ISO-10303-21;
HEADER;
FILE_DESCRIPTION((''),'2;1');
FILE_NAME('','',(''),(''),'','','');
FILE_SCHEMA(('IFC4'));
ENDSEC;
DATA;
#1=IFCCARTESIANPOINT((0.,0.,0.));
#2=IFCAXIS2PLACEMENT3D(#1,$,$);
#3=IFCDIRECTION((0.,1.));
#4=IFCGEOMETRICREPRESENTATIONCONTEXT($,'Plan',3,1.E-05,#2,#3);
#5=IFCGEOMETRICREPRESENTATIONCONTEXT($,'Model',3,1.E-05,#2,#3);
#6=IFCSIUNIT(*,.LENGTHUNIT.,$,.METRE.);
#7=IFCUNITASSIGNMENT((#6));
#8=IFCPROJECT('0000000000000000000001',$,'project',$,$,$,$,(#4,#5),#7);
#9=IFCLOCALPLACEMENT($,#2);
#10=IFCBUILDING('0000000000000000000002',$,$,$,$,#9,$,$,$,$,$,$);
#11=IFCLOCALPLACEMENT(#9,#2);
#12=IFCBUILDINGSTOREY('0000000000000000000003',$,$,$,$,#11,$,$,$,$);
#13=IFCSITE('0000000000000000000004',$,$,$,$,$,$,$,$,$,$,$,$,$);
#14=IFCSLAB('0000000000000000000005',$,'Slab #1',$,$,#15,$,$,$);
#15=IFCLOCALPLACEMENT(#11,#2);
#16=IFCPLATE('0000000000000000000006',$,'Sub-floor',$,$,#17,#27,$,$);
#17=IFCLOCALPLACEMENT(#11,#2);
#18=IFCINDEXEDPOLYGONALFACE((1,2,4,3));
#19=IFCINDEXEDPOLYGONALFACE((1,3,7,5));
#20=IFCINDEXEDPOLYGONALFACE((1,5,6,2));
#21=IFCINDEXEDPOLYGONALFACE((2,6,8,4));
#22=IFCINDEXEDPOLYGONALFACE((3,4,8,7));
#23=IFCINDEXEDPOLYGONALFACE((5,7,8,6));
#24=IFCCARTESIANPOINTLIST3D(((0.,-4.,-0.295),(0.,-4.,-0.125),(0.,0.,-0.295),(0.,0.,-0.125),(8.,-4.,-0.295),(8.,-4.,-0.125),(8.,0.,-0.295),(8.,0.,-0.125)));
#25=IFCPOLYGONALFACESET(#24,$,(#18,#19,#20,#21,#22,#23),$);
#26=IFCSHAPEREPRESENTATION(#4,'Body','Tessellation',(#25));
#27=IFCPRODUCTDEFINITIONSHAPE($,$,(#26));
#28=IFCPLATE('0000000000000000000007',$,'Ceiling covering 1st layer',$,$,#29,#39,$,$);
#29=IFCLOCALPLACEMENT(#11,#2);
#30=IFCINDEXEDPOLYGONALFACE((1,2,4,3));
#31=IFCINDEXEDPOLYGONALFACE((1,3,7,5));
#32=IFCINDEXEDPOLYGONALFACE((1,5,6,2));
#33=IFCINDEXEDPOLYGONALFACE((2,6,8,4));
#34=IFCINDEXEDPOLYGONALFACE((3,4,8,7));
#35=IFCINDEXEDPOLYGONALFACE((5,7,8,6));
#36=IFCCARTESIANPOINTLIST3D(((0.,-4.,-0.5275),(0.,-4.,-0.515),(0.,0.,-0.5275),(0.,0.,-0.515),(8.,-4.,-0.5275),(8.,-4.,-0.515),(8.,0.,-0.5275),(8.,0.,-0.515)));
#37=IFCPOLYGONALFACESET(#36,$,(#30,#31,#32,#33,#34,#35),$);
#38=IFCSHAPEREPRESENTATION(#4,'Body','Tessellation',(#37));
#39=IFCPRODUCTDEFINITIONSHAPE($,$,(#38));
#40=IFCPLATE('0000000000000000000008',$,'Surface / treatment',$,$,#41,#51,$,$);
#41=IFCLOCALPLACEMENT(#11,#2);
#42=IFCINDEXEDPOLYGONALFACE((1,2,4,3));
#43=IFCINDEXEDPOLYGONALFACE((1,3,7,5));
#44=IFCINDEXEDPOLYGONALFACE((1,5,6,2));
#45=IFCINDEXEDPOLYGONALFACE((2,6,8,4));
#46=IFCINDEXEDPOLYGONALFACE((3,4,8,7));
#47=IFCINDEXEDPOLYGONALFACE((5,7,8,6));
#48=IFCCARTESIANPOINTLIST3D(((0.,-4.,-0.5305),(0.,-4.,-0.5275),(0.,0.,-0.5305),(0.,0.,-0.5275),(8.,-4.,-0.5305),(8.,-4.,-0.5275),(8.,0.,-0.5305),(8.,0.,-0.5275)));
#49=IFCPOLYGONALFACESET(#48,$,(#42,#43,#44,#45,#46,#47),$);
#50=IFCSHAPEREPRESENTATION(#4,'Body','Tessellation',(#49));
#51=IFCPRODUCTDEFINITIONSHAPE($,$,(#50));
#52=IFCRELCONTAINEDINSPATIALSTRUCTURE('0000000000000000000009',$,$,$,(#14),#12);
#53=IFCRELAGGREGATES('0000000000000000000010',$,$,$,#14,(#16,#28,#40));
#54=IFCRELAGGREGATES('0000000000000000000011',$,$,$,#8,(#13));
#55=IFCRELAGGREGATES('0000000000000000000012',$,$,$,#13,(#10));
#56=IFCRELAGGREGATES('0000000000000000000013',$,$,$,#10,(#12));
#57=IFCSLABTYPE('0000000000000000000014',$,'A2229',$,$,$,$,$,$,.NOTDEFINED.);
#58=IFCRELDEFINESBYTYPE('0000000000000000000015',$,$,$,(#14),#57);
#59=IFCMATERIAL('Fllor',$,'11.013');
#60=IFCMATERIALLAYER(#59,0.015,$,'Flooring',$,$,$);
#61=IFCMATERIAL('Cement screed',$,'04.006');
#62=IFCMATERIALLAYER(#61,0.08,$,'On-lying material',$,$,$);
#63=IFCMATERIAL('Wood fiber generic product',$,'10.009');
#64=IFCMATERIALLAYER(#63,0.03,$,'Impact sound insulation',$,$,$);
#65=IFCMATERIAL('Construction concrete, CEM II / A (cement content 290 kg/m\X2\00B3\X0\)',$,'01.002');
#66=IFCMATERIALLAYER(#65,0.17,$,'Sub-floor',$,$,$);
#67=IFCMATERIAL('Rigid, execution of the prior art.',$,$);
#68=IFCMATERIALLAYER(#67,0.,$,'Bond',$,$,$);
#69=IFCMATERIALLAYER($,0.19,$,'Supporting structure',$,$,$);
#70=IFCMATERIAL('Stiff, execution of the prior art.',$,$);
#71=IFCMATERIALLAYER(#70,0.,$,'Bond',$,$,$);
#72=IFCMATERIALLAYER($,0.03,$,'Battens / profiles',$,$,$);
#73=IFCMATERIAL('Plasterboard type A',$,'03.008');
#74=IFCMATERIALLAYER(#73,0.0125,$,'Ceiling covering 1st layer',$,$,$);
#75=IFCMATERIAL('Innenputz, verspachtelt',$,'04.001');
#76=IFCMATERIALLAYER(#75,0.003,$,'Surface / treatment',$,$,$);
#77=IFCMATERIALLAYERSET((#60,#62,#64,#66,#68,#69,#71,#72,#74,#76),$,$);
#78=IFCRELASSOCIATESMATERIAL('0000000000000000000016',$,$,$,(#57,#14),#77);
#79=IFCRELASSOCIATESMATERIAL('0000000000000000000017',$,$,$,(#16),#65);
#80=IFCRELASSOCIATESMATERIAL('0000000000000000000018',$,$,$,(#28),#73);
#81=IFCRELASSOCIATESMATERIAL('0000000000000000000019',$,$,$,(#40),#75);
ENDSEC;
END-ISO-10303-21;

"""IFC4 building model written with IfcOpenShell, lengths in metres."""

from ifc_helpers import new_model, si_unit, direction, frame, frame_2d, origin, place, context, project, spatial, rectangle, extrude, material, layer, layer_set, type_object, element, aggregate, save


model = new_model("IFC4")

# Units and contexts
plan_context = context("Plan", 3, precision=1e-05, world=origin(), true_north=direction((0.0, 1.0)))
model_context = context("Model", 3, precision=1e-05, world=origin(), true_north=direction((0.0, 1.0)))
ifc_project = project(units=[si_unit("LENGTHUNIT", "METRE")], contexts=[plan_context, model_context])

# Site, building, storey
site = spatial("IfcSite", under=ifc_project)
building_placement = place(None, origin())
building = spatial("IfcBuilding", under=site, at=building_placement)
storey_placement = place(building_placement, origin())
storey = spatial("IfcBuildingStorey", under=building, at=storey_placement)

# Slab, plates
ifc_material_1 = material(Name="Fllor", Category="11.013")
ifc_layer_1 = layer(ifc_material_1, 0.015, Name="Flooring")
ifc_material_2 = material(Name="Cement screed", Category="04.006")
ifc_layer_2 = layer(ifc_material_2, 0.08, Name="On-lying material")
ifc_material_3 = material(Name="Wood fiber generic product", Category="10.009")
ifc_layer_3 = layer(ifc_material_3, 0.03, Name="Impact sound insulation")
ifc_material_4 = material(Name="Construction concrete, CEM II / A (cement content 290 kg/m³)", Category="01.002")
ifc_layer_4 = layer(ifc_material_4, 0.17, Name="Sub-floor")
ifc_material_5 = material(Name="Rigid, execution of the prior art.")
ifc_layer_5 = layer(ifc_material_5, 0.0, Name="Bond")
ifc_layer_6 = layer(None, 0.19, Name="Supporting structure")
ifc_material_6 = material(Name="Stiff, execution of the prior art.")
ifc_layer_7 = layer(ifc_material_6, 0.0, Name="Bond")
ifc_layer_8 = layer(None, 0.03, Name="Battens / profiles")
ifc_material_7 = material(Name="Plasterboard type A", Category="03.008")
ifc_layer_9 = layer(ifc_material_7, 0.0125, Name="Ceiling covering 1st layer")
ifc_material_8 = material(Name="Innenputz, verspachtelt", Category="04.001")
ifc_layer_10 = layer(ifc_material_8, 0.003, Name="Surface / treatment")
ifc_layer_set = layer_set([ifc_layer_1, ifc_layer_2, ifc_layer_3, ifc_layer_4, ifc_layer_5, ifc_layer_6, ifc_layer_7, ifc_layer_8, ifc_layer_9, ifc_layer_10])
slab_type = type_object("IfcSlabType", Name="A2229", PredefinedType="NOTDEFINED", material=ifc_layer_set)
slab_placement = place(None, frame((0.0, 0.0, 0.0), z_axis=(0.0, 0.0, -1.0), x_axis=(1.0, 0.0, 0.0)))
slab = element("IfcSlab", 1, at=slab_placement, inside=storey, type_object=slab_type, material=ifc_layer_set, Name="Slab #1")
plate_1_placement = place(slab_placement, origin())
plate_1 = element("IfcPlate", 2, at=plate_1_placement, material=ifc_material_4, Name="Sub-floor", context=plan_context, shape_type="SweptSolid", body=[
    extrude(rectangle(XDim=8.0, YDim=4.0, at=frame_2d((4.0, 2.0), x_axis=(1.0, 0.0))), frame((0.0, 0.0, 0.125), z_axis=(0.0, 0.0, 1.0), x_axis=(1.0, 0.0, 0.0)), (0.0, 0.0, 1.0), 0.17),
])
plate_2_placement = place(slab_placement, origin())
plate_2 = element("IfcPlate", 3, at=plate_2_placement, material=ifc_material_7, Name="Ceiling covering 1st layer", context=plan_context, shape_type="SweptSolid", body=[
    extrude(rectangle(XDim=8.0, YDim=4.0, at=frame_2d((4.0, 2.0), x_axis=(1.0, 0.0))), frame((0.0, 0.0, 0.515), z_axis=(0.0, 0.0, 1.0), x_axis=(1.0, 0.0, 0.0)), (0.0, 0.0, 1.0), 0.0125),
])
plate_3_placement = place(slab_placement, origin())
plate_3 = element("IfcPlate", 4, at=plate_3_placement, material=ifc_material_8, Name="Surface / treatment", context=plan_context, shape_type="SweptSolid", body=[
    extrude(rectangle(XDim=8.0, YDim=4.0, at=frame_2d((4.0, 2.0), x_axis=(1.0, 0.0))), frame((0.0, 0.0, 0.5275), z_axis=(0.0, 0.0, 1.0), x_axis=(1.0, 0.0, 0.0)), (0.0, 0.0, 1.0), 0.003),
])
aggregate(slab, [plate_1, plate_2, plate_3])

save(model, "model.ifc")
